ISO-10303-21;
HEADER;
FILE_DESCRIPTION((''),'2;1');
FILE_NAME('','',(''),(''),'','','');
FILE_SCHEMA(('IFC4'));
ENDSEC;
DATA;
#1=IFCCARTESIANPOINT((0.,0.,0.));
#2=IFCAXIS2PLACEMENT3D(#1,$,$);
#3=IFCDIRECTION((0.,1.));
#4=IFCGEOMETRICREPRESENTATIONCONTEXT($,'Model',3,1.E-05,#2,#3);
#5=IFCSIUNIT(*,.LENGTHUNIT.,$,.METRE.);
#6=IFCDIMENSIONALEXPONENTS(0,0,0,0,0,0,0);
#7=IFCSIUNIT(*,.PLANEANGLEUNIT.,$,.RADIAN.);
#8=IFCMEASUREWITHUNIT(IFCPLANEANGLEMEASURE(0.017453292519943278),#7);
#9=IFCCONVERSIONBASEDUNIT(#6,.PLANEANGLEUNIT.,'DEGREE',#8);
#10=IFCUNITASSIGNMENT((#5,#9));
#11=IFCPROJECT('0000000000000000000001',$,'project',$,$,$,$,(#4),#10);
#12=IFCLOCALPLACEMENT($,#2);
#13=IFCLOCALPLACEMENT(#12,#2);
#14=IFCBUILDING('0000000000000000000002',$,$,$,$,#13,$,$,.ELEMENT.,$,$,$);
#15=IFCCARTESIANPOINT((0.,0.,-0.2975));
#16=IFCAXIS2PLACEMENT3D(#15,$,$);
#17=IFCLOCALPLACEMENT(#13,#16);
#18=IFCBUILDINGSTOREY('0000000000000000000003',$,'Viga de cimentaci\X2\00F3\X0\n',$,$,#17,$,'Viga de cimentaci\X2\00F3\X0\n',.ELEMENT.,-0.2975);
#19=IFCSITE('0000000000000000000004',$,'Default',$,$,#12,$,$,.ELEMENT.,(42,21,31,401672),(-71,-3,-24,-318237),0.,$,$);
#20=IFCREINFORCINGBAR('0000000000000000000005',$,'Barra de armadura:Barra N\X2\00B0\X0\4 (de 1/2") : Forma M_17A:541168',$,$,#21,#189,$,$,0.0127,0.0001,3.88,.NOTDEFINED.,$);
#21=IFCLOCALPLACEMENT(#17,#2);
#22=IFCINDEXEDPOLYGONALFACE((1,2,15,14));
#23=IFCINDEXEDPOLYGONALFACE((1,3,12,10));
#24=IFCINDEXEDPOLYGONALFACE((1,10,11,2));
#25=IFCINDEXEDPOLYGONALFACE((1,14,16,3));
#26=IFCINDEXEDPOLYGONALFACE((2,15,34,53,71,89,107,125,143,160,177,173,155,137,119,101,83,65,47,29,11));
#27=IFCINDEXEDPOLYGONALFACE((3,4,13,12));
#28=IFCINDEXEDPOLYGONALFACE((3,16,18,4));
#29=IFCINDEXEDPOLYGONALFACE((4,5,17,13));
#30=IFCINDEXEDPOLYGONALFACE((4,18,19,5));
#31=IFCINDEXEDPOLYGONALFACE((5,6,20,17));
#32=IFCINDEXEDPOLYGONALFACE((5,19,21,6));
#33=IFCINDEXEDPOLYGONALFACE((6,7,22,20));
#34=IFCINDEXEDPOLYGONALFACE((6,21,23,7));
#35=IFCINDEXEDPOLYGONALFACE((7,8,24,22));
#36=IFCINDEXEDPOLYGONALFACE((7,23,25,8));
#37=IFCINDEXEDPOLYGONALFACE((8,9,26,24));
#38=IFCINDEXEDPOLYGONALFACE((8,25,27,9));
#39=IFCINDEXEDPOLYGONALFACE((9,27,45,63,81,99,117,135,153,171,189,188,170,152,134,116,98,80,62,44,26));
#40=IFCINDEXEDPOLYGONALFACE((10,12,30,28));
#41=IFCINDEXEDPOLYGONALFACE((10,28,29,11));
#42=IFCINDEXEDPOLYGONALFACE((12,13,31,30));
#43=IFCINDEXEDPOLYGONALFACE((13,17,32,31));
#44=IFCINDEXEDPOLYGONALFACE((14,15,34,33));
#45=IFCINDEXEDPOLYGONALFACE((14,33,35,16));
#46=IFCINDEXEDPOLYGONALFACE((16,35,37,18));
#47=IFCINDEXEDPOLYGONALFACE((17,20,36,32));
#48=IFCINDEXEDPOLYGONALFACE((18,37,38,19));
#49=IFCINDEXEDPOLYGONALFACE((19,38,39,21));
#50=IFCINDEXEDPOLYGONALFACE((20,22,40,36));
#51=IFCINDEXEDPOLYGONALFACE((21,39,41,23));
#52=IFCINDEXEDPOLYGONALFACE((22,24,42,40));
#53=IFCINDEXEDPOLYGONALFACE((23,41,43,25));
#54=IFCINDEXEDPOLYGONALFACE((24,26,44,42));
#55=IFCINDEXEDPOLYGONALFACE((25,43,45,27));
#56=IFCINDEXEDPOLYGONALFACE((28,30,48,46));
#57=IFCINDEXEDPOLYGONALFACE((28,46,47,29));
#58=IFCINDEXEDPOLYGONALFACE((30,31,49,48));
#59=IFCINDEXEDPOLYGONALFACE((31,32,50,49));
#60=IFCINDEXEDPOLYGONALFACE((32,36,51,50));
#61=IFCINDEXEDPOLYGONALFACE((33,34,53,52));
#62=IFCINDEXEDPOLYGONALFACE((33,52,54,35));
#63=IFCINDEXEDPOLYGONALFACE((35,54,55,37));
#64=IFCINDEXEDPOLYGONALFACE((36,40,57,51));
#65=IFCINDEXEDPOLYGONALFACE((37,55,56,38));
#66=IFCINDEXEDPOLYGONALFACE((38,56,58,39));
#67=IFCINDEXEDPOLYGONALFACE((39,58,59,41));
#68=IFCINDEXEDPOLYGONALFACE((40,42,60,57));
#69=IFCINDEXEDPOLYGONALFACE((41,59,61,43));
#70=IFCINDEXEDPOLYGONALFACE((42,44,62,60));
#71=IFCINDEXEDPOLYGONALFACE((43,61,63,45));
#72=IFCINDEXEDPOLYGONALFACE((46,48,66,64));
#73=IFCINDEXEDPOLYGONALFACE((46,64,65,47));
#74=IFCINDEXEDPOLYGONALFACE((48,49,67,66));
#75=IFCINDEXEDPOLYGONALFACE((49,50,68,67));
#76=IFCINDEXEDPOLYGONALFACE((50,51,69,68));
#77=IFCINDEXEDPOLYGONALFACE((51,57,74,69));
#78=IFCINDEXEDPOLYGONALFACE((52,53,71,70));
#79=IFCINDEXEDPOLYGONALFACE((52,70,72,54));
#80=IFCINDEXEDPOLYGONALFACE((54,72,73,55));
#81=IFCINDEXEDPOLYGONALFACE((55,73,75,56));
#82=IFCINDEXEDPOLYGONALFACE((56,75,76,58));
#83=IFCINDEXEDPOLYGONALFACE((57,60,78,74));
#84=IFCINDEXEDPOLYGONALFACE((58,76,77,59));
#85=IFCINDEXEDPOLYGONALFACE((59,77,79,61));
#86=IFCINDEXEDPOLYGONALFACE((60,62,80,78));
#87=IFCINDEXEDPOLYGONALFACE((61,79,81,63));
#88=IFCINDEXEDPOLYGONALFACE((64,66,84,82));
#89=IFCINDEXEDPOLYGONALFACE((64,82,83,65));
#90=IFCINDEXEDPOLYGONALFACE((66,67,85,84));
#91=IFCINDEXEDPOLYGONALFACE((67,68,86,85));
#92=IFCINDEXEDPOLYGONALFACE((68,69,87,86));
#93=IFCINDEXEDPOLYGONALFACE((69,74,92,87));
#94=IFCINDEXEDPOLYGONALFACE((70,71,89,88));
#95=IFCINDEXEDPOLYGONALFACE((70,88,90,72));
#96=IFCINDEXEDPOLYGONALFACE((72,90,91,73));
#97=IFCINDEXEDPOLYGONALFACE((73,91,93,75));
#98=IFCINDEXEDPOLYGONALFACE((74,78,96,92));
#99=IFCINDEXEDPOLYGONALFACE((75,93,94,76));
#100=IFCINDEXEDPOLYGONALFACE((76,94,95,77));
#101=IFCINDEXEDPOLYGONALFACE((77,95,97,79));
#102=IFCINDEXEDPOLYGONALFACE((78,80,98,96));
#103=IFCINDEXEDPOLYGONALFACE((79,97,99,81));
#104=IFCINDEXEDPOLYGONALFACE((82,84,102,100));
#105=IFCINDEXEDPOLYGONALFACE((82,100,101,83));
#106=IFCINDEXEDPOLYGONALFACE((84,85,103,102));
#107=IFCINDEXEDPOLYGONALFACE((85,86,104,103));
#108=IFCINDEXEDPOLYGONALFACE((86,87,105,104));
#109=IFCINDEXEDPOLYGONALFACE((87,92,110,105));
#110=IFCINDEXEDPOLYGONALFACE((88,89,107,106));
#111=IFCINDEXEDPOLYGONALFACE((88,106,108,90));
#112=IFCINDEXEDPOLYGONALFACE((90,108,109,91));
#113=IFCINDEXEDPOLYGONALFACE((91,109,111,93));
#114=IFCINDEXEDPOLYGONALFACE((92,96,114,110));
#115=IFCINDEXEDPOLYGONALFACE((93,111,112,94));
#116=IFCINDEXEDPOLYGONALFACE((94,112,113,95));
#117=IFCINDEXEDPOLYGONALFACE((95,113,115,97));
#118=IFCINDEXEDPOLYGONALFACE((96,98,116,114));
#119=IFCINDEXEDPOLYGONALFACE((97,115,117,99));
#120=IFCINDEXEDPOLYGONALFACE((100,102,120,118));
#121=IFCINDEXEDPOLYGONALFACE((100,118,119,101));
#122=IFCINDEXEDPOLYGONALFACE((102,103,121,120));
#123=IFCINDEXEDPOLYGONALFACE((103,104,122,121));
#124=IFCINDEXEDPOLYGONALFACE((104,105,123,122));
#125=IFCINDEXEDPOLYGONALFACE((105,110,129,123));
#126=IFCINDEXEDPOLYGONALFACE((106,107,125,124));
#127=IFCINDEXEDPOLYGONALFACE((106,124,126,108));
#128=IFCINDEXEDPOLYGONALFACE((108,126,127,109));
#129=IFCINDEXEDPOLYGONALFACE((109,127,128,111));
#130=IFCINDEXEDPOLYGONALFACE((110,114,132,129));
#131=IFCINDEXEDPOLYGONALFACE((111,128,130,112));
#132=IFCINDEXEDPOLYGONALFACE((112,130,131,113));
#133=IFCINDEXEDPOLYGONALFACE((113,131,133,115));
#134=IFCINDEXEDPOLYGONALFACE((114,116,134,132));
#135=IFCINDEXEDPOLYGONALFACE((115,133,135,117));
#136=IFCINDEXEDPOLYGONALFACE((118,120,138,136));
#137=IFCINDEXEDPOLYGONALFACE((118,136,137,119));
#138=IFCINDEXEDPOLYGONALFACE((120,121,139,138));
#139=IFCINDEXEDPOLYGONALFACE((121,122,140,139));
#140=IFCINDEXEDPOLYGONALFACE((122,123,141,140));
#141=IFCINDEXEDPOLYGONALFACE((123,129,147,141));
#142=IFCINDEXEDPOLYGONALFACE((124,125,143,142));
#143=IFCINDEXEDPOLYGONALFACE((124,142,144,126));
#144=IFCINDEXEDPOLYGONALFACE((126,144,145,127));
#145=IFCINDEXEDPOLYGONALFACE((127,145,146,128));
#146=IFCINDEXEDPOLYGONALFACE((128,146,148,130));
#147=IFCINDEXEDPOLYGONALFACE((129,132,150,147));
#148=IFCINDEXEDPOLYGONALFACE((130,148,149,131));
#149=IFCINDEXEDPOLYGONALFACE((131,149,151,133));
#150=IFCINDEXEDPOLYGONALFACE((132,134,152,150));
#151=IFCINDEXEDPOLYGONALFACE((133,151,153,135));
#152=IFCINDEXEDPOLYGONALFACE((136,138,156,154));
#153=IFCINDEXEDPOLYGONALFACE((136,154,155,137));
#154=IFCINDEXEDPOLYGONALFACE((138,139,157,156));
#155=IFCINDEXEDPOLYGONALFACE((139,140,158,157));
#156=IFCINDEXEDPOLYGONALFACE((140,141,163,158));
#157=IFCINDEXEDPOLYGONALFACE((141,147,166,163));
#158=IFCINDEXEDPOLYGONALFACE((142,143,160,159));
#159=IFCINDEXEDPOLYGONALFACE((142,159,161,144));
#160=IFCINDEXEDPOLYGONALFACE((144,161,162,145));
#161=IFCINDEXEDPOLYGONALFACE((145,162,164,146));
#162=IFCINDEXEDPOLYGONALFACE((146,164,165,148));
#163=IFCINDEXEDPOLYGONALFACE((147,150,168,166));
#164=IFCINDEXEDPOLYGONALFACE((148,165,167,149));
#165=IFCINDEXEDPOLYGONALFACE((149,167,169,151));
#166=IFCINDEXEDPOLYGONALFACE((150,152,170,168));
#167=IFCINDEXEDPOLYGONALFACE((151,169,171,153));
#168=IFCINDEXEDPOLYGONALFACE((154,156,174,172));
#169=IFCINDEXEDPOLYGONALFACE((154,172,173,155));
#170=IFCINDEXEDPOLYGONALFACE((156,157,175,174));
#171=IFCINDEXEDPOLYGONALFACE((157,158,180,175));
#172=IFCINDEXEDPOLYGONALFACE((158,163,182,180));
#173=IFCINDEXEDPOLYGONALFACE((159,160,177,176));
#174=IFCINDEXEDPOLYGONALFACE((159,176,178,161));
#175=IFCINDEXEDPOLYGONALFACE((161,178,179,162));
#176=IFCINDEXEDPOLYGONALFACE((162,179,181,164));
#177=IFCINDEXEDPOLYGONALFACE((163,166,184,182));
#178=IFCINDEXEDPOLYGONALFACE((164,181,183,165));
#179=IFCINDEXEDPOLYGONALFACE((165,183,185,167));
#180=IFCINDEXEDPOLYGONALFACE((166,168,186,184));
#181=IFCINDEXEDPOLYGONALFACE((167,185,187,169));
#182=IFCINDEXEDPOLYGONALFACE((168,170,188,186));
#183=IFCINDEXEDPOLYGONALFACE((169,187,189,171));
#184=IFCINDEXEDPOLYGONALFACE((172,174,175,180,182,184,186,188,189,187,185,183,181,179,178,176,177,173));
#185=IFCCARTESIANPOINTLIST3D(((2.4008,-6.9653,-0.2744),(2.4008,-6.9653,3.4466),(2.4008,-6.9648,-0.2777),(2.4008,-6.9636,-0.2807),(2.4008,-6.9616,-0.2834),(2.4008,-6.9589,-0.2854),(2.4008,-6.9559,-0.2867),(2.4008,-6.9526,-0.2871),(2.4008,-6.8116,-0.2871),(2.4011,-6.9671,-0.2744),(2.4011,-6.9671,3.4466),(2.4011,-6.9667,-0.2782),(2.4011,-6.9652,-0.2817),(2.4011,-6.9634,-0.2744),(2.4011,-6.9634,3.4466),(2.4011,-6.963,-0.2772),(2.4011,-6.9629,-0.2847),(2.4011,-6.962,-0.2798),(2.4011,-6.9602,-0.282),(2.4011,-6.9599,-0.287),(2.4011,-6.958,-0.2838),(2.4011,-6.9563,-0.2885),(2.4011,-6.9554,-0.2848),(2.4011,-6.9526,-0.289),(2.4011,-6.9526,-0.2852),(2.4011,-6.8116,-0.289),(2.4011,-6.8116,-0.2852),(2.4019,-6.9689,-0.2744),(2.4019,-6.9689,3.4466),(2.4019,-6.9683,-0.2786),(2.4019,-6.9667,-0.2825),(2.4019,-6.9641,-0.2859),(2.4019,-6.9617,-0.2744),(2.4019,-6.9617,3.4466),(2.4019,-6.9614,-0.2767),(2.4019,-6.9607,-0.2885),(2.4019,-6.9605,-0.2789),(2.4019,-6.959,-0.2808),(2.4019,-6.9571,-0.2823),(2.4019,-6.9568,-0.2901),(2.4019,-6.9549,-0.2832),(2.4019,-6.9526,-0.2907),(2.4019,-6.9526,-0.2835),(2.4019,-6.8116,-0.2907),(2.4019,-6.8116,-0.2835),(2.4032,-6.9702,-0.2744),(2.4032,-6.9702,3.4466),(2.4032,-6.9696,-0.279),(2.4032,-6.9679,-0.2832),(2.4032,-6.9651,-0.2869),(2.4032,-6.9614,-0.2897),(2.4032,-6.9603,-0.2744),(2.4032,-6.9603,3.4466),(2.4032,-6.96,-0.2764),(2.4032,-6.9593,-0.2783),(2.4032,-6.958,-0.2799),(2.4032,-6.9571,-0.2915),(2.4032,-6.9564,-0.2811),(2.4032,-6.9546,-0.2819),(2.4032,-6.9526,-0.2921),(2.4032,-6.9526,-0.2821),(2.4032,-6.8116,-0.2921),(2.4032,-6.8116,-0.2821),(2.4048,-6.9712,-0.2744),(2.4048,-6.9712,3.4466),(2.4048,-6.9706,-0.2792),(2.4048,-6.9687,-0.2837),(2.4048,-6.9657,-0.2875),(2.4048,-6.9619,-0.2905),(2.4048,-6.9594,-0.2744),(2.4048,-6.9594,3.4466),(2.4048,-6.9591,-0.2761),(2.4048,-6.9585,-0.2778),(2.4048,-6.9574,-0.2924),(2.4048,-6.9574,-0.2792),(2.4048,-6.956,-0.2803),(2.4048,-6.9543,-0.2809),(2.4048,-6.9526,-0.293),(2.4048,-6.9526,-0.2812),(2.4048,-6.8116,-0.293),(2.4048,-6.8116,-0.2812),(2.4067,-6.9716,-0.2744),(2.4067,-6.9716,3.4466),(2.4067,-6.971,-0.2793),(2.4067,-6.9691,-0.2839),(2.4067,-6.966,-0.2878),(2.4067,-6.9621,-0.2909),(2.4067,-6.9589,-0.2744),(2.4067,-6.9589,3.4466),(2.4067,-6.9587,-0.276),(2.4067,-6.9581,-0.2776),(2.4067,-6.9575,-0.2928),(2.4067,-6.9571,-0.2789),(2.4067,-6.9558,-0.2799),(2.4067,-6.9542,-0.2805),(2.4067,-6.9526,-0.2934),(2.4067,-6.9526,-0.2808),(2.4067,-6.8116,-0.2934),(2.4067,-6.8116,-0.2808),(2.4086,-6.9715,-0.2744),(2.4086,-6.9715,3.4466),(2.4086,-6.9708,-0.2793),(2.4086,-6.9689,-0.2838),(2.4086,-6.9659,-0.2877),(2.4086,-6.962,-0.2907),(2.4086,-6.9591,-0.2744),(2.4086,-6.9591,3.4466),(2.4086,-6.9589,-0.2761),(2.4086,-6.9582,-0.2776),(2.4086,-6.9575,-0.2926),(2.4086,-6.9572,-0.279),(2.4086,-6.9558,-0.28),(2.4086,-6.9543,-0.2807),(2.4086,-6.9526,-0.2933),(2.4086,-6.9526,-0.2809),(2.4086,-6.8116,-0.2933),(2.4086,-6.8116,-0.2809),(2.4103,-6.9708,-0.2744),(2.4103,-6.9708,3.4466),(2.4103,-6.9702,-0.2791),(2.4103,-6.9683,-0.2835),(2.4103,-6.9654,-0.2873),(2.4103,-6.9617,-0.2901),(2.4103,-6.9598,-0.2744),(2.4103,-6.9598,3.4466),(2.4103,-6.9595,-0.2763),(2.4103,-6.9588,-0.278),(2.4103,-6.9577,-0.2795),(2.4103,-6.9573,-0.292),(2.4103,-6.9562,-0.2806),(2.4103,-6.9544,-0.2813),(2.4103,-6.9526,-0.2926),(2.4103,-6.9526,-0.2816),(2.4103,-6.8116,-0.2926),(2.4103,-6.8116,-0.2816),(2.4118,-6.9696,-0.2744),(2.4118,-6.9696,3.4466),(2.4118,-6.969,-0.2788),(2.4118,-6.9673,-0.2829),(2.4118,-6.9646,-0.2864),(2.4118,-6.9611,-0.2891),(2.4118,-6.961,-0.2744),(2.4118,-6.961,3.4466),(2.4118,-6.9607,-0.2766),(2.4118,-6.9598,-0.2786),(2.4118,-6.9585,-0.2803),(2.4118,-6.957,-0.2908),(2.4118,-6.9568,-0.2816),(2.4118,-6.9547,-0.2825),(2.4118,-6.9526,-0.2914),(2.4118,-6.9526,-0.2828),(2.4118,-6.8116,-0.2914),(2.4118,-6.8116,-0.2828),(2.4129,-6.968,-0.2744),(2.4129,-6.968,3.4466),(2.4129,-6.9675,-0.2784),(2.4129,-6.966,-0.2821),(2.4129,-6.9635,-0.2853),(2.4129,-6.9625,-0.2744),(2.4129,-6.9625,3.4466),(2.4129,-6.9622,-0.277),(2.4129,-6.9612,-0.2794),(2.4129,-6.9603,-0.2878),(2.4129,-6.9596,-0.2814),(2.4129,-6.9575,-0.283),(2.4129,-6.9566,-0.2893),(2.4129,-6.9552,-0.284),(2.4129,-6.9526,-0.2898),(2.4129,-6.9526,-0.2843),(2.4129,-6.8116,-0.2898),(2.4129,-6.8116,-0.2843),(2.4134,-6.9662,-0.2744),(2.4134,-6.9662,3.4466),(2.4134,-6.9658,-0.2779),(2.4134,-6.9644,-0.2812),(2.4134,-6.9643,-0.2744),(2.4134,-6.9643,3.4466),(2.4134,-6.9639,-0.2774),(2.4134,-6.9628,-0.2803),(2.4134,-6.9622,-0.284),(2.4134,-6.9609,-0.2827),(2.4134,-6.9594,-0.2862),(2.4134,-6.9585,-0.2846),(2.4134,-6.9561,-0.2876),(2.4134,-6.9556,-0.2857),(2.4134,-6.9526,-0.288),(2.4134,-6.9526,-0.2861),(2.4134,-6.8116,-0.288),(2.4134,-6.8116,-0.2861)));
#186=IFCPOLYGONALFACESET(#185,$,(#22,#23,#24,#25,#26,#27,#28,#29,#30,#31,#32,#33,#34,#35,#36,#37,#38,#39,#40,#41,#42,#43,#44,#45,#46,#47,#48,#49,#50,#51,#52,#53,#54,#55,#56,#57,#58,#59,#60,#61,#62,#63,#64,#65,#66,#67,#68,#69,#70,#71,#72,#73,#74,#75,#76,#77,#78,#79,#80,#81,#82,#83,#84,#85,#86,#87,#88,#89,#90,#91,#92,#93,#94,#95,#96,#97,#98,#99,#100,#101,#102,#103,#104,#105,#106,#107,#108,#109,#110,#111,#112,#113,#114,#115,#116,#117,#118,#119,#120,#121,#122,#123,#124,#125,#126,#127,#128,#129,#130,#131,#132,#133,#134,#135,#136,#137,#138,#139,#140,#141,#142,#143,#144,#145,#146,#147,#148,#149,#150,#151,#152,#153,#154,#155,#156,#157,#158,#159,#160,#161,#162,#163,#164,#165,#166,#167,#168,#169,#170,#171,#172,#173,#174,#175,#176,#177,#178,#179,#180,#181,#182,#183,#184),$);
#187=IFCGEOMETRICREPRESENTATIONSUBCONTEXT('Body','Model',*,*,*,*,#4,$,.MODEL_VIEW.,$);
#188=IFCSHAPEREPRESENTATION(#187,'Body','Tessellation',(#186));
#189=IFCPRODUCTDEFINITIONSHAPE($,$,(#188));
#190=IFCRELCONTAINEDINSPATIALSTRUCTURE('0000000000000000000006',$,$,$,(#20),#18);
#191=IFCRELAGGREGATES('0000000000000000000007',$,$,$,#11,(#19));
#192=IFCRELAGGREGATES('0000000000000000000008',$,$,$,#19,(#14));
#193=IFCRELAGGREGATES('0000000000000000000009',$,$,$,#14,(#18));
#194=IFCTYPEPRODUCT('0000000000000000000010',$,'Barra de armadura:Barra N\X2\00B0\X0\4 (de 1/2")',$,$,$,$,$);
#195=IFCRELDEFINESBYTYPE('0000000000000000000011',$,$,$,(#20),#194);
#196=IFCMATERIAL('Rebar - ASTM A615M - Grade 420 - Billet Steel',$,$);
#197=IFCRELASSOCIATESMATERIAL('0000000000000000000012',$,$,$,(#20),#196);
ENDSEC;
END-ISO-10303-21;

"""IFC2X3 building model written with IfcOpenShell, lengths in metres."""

from ifc_helpers import new_model, entity, si_unit, converted_unit, direction, frame, origin, place, context, subcontext, project, spatial, material, type_object, element, save


model = new_model("IFC2X3")

# Units and contexts
model_context = context("Model", 3, precision=1e-05, world=origin(), true_north=direction((0.0, 1.0)))
body_context = subcontext(model_context, "Body", "Model", "MODEL_VIEW")
ifc_project = project(units=[si_unit("LENGTHUNIT", "METRE"), converted_unit("PLANEANGLEUNIT", "DEGREE", entity("IfcPlaneAngleMeasure", 0.017453292519943278), si_unit("PLANEANGLEUNIT", "RADIAN"), dimensions=[0, 0, 0, 0, 0, 0, 0])], contexts=[model_context])

# Site, building, storey
site_placement = place(None, origin())
site = spatial("IfcSite", under=ifc_project, at=site_placement, Name="Default", CompositionType="ELEMENT", RefLatitude=(42, 21, 31, 401672), RefLongitude=(-71, -3, -24, -318237), RefElevation=0.0)
building_placement = place(site_placement, origin())
building = spatial("IfcBuilding", under=site, at=building_placement, CompositionType="ELEMENT")
storey_placement = place(building_placement, frame((0.0, 0.0, -0.2975)))
storey = spatial("IfcBuildingStorey", under=building, at=storey_placement, Name="Viga de cimentación", LongName="Viga de cimentación", CompositionType="ELEMENT", Elevation=-0.2975)

# Reinforcing bar
ifc_material_1 = material(Name="Rebar - ASTM A615M - Grade 420 - Billet Steel")
type_product_1 = type_object("IfcTypeProduct", Name="Barra de armadura:Barra N°4 (de 1/2\")")
reinforcing_bar_1_placement = place(storey_placement, origin())
element("IfcReinforcingBar", 1, at=reinforcing_bar_1_placement, inside=storey, type_object=type_product_1, material=ifc_material_1, Name="Barra de armadura:Barra N°4 (de 1/2\") : Forma M_17A:541168", BarLength=3.88, BarRole="NOTDEFINED", CrossSectionArea=0.0001, NominalDiameter=0.0127, context=body_context, shape_type="AdvancedSweptSolid", body=[
    entity("IfcSweptDiskSolid", entity("IfcCompositeCurve", [entity("IfcCompositeCurveSegment", "CONTINUOUS", True, entity("IfcPolyline", [entity("IfcCartesianPoint", [2.4071, -6.9653, 3.4466]), entity("IfcCartesianPoint", [2.4071, -6.9653, -0.2744])])), entity("IfcCompositeCurveSegment", "CONTINUOUS", True, entity("IfcTrimmedCurve", entity("IfcCircle", entity("IfcAxis2Placement3D", entity("IfcCartesianPoint", [2.4071, -6.9526, -0.2744]), entity("IfcDirection", [1.0, 0.0, 0.0]), entity("IfcDirection", [0.0, 0.0, -1.0])), 0.0127), [entity("IfcParameterValue", 270.0)], [entity("IfcParameterValue", 360.0)], True, "PARAMETER")), entity("IfcCompositeCurveSegment", "CONTINUOUS", True, entity("IfcPolyline", [entity("IfcCartesianPoint", [2.4071, -6.9526, -0.2871]), entity("IfcCartesianPoint", [2.4071, -6.8116, -0.2871])]))], False), 0.0063, None, 0.0, 92.0),
])

save(model, "model.ifc")
